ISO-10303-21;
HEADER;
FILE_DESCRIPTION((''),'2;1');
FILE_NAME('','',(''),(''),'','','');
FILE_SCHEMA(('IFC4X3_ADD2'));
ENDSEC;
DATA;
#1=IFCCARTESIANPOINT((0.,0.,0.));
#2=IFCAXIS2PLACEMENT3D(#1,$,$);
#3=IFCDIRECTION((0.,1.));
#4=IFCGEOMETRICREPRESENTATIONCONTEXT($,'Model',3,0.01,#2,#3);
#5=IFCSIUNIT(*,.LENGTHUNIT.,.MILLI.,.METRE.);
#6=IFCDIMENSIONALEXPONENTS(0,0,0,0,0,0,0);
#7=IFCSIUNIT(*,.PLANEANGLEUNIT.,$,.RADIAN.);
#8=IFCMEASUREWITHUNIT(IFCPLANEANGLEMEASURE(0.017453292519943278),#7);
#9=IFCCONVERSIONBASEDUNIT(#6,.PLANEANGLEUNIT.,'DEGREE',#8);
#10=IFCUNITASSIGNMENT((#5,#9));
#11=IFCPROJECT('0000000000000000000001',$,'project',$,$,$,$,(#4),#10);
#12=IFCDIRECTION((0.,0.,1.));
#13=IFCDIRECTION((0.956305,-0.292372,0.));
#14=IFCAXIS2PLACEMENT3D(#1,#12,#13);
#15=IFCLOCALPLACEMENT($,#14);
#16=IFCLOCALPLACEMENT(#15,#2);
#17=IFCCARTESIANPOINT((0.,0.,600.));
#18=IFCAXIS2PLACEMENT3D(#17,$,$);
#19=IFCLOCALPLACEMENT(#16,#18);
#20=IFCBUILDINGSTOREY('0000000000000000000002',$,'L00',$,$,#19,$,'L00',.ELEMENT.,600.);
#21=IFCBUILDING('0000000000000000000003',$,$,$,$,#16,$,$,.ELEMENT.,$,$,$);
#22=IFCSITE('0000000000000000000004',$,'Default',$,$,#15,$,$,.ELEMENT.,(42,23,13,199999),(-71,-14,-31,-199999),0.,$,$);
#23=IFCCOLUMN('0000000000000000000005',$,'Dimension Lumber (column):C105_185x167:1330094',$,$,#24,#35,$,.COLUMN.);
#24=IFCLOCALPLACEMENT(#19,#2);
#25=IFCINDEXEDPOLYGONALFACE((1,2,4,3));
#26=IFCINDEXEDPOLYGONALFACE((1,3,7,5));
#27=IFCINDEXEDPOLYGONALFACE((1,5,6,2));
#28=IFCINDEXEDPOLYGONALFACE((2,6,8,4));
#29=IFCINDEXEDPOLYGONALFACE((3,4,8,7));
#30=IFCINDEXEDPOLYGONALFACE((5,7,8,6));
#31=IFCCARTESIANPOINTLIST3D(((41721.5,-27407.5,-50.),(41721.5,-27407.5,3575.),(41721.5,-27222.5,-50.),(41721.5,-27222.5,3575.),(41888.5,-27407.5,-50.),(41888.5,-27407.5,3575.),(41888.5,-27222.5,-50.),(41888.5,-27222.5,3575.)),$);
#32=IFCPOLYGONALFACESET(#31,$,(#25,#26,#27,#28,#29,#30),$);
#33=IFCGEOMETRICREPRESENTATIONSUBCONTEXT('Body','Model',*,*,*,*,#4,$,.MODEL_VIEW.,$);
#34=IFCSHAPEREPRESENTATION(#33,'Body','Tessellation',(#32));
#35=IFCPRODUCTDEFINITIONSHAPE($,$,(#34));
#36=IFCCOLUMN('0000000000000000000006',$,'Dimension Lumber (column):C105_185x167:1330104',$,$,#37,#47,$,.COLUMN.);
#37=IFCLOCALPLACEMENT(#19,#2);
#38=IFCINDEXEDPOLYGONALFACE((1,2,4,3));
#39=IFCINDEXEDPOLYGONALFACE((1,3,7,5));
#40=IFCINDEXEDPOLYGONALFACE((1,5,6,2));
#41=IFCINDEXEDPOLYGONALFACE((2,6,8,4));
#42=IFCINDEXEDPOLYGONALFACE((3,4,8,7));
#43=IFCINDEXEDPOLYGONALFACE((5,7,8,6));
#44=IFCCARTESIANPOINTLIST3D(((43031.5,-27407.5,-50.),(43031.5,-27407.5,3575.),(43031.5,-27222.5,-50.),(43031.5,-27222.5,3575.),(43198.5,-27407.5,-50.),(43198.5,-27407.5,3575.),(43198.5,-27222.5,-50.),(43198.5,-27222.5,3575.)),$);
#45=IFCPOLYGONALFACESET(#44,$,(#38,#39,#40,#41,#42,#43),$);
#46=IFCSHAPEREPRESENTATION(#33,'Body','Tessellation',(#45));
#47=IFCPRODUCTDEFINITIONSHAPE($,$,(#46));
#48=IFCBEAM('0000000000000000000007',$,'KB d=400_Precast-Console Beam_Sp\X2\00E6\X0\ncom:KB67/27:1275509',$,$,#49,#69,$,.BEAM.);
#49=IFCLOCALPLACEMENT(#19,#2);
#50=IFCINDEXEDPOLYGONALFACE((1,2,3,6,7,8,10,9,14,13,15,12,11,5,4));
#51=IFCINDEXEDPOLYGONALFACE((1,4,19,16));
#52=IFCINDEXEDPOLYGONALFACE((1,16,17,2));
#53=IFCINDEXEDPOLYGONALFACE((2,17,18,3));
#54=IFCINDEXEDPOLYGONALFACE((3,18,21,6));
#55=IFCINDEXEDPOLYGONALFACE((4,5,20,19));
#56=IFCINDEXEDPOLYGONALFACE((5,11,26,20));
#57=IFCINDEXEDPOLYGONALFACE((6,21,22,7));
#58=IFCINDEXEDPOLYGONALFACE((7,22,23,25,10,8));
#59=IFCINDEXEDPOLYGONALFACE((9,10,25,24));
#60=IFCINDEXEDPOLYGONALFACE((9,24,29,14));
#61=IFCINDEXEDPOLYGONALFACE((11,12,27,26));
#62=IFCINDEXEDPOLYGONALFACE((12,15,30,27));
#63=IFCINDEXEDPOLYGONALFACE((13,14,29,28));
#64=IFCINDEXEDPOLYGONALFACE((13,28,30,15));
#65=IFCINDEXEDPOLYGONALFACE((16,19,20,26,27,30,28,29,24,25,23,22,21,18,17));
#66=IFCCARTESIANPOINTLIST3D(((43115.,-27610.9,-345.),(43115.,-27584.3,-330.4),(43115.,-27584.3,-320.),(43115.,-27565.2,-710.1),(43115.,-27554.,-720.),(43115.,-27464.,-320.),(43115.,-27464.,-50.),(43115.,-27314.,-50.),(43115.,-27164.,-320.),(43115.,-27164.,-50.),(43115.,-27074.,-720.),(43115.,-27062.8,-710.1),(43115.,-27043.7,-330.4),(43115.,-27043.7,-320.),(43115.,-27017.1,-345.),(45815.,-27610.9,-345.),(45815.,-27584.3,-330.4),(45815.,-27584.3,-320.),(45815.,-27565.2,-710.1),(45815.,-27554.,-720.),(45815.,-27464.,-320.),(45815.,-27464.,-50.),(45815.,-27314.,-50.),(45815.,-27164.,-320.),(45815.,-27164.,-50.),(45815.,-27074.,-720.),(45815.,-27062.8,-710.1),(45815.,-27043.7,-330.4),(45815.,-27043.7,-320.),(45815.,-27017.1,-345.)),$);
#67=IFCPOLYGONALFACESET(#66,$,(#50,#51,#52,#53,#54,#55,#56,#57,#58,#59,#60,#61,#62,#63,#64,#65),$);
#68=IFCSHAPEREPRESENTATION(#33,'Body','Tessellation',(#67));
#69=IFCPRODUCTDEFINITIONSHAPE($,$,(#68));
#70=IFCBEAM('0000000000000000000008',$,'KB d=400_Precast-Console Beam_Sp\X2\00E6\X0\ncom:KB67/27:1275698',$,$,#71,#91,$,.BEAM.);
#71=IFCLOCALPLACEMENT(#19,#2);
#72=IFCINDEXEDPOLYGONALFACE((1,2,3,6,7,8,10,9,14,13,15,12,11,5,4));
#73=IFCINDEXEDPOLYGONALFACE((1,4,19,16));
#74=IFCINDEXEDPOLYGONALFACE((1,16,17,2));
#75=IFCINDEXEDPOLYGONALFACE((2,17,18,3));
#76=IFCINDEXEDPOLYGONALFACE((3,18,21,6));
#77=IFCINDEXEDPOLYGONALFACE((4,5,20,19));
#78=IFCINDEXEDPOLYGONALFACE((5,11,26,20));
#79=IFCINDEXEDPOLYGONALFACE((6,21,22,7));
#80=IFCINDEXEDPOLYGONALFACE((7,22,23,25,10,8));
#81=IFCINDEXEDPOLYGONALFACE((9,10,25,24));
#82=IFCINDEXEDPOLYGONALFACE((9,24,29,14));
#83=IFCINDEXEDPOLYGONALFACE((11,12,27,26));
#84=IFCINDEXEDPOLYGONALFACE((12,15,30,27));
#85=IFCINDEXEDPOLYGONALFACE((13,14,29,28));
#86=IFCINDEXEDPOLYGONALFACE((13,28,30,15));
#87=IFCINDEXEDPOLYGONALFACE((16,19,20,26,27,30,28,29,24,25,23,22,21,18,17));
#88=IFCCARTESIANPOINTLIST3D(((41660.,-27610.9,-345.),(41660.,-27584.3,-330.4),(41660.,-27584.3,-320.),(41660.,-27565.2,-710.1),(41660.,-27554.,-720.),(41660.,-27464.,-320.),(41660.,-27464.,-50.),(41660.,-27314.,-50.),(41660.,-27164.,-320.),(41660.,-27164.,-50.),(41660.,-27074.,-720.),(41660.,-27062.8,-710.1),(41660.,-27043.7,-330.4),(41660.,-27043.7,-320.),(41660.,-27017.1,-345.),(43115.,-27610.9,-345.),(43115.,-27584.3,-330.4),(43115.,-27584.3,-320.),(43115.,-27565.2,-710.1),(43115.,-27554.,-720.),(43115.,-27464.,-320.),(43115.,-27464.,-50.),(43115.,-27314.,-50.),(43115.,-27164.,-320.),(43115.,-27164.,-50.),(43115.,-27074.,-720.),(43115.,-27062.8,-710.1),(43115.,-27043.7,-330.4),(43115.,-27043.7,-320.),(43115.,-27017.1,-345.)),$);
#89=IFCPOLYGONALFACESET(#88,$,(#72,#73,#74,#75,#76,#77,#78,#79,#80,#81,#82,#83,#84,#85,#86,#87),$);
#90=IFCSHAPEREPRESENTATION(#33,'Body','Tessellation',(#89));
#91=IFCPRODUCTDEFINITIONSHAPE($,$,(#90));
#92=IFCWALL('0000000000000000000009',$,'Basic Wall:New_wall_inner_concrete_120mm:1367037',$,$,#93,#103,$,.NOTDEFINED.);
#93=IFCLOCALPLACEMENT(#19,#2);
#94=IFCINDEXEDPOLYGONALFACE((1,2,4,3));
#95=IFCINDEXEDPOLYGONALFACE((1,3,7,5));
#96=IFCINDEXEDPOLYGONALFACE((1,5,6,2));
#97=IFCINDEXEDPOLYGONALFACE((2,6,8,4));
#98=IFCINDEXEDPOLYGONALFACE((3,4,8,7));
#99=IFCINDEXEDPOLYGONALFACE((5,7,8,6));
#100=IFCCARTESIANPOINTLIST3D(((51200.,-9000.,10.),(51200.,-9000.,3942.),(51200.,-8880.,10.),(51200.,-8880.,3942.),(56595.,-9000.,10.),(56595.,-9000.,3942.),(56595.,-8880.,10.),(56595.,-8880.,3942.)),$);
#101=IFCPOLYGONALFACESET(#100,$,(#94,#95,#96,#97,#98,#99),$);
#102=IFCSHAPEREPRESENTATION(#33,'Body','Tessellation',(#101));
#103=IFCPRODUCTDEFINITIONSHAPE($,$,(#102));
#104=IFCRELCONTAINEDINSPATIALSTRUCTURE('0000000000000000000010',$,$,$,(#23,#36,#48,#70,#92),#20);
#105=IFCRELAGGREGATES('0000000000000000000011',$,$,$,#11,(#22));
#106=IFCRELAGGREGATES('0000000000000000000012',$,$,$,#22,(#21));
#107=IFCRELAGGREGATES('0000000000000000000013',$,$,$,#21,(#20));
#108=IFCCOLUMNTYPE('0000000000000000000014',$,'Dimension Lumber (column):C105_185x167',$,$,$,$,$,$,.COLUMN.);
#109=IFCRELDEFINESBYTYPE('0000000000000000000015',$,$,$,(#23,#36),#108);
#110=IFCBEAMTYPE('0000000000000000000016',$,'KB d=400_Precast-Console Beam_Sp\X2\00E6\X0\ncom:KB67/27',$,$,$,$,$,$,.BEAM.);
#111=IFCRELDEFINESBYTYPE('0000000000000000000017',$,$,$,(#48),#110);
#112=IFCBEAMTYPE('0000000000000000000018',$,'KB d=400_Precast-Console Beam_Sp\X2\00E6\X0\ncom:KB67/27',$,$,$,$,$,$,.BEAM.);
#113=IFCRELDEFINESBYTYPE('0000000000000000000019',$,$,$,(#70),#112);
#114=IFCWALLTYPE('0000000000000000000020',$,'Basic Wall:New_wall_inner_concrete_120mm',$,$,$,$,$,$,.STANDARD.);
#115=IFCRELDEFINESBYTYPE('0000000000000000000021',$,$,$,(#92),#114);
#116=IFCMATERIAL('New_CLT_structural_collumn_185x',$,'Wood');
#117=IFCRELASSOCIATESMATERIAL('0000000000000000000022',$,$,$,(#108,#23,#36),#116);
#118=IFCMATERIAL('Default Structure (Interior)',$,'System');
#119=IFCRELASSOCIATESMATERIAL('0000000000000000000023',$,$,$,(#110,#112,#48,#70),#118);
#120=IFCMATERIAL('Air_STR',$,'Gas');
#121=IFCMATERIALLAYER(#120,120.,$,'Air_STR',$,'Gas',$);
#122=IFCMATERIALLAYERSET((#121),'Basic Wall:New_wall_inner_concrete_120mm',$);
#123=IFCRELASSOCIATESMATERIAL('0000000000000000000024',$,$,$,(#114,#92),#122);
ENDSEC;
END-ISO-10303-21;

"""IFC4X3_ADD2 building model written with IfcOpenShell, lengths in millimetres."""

from ifc_helpers import new_model, entity, si_unit, converted_unit, direction, frame, frame_2d, origin, origin_2d_with_axis, place, context, subcontext, project, spatial, polyline, rectangle, outline, extrude, source, transform, mapped, material, layer, layer_set, material_profile, profile_set, profile_usage, type_object, type_shapes, element, save


model = new_model("IFC4X3_ADD2")

# Units and contexts
model_context = context("Model", 3, precision=0.01, world=origin(), true_north=direction((0.0, 1.0)))
body_context = subcontext(model_context, "Body", "Model", "MODEL_VIEW")
ifc_project = project(units=[si_unit("LENGTHUNIT", "METRE", prefix="MILLI"), converted_unit("PLANEANGLEUNIT", "DEGREE", entity("IfcPlaneAngleMeasure", 0.017453292519943278), si_unit("PLANEANGLEUNIT", "RADIAN"), dimensions=[0, 0, 0, 0, 0, 0, 0])], contexts=[model_context])

# Site, building, storey
site_placement = place(None, frame((0.0, 0.0, 0.0), z_axis=(0.0, 0.0, 1.0), x_axis=(0.956305, -0.292372, 0.0)))
site = spatial("IfcSite", under=ifc_project, at=site_placement, Name="Default", CompositionType="ELEMENT", RefLatitude=(42, 23, 13, 199999), RefLongitude=(-71, -14, -31, -199999), RefElevation=0.0)
building_placement = place(site_placement, origin())
building = spatial("IfcBuilding", under=site, at=building_placement, CompositionType="ELEMENT")
storey_placement = place(building_placement, frame((0.0, 0.0, 600.0)))
storey = spatial("IfcBuildingStorey", under=building, at=storey_placement, Name="L00", LongName="L00", CompositionType="ELEMENT", Elevation=600.0)

# Columns
ifc_material_1 = material(Name="New_CLT_structural_collumn_185x", Category="Wood")
ifc_material_profile_1 = material_profile(ifc_material_1, rectangle(XDim=185.0, YDim=167.0, at=origin_2d_with_axis()), Name="C105_185x167")
ifc_profile_set_1 = profile_set([ifc_material_profile_1], Name="C105_185x167")
ifc_profile_usage_1 = profile_usage(ifc_profile_set_1)
column_type = type_object("IfcColumnType", Name="Dimension Lumber (column):C105_185x167", PredefinedType="COLUMN", material=ifc_profile_set_1)
shared_shape_1 = source(origin(), body_context, "Body", "SweptSolid", [
    extrude(rectangle(XDim=185.0, YDim=167.0, at=origin_2d_with_axis()), frame((0.0, 0.0, 550.0), z_axis=(0.0, 0.0, 1.0), x_axis=(-1.0, 0.0, 0.0)), (0.0, 0.0, 1.0), 3625.0),
])
type_shapes(column_type, [shared_shape_1])
for number, where, z_axis, x_axis, name in (
    (1, (41805.0, -27315.0, -600.0), (0.0, 0.0, 1.0), (0.0, 1.0, 0.0), "Dimension Lumber (column):C105_185x167:1330094"),
    (2, (43115.0, -27315.0, -600.0), (0.0, 0.0, 1.0), (0.0, 1.0, 0.0), "Dimension Lumber (column):C105_185x167:1330104"),
):
    element("IfcColumn", number, at=place(storey_placement, frame(where, z_axis=z_axis, x_axis=x_axis)), inside=storey, type_object=column_type, material=ifc_profile_usage_1, Name=name, PredefinedType="COLUMN", context=body_context, shape_type="MappedRepresentation", body=[
        mapped(shared_shape_1, transform((0.0, 0.0, 0.0), scale=1.0)),
    ])

# Beams
ifc_material_2 = material(Name="Default Structure (Interior)", Category="System")
ifc_material_profile_2 = material_profile(ifc_material_2, outline(polyline([(-240.0, -343.9), (240.0, -343.9), (251.2, -334.0), (296.9, 31.1), (270.3, 45.7), (270.3, 56.1), (150.0, 56.1), (150.0, 326.1), (0.0, 326.1), (-150.0, 326.1), (-150.0, 56.1), (-270.3, 56.1), (-270.3, 45.7), (-296.9, 31.1), (-251.2, -334.0), (-240.0, -343.9)])), Name="KB67/27")
ifc_profile_set_2 = profile_set([ifc_material_profile_2], Name="KB67/27")
ifc_profile_usage_2 = profile_usage(ifc_profile_set_2, cardinal=8)
beam_type_1 = type_object("IfcBeamType", Name="KB d=400_Precast-Console Beam_Spæncom:KB67/27", PredefinedType="BEAM", material=ifc_profile_set_2)
shared_shape_2 = source(origin(), body_context, "Body", "SweptSolid", [
    extrude(outline(polyline([(-240.0, -343.9), (240.0, -343.9), (251.2, -334.0), (296.9, 31.1), (270.3, 45.7), (270.3, 56.1), (150.0, 56.1), (150.0, 326.1), (0.0, 326.1), (-150.0, 326.1), (-150.0, 56.1), (-270.3, 56.1), (-270.3, 45.7), (-296.9, 31.1), (-251.2, -334.0), (-240.0, -343.9)])), frame((-1350.0, 0.0, 343.9), z_axis=(1.0, 0.0, 0.0), x_axis=(0.0, 1.0, 0.0)), (0.0, 0.0, 1.0), 2700.0),
])
type_shapes(beam_type_1, [shared_shape_2])
beam_1_placement = place(storey_placement, frame((44465.0, -27314.0, -720.0)))
element("IfcBeam", 3, at=beam_1_placement, inside=storey, type_object=beam_type_1, material=ifc_profile_usage_2, Name="KB d=400_Precast-Console Beam_Spæncom:KB67/27:1275509", PredefinedType="BEAM", context=body_context, shape_type="MappedRepresentation", body=[
    mapped(shared_shape_2, transform((0.0, 0.0, 0.0), scale=1.0)),
])
beam_type_2 = type_object("IfcBeamType", Name="KB d=400_Precast-Console Beam_Spæncom:KB67/27", PredefinedType="BEAM", material=ifc_profile_set_2)
shared_shape_3 = source(origin(), body_context, "Body", "SweptSolid", [
    extrude(outline(polyline([(-240.0, -343.9), (240.0, -343.9), (251.2, -334.0), (296.9, 31.1), (270.3, 45.7), (270.3, 56.1), (150.0, 56.1), (150.0, 326.1), (0.0, 326.1), (-150.0, 326.1), (-150.0, 56.1), (-270.3, 56.1), (-270.3, 45.7), (-296.9, 31.1), (-251.2, -334.0), (-240.0, -343.9)])), frame((-727.5, 0.0, 343.9), z_axis=(1.0, 0.0, 0.0), x_axis=(0.0, 1.0, 0.0)), (0.0, 0.0, 1.0), 1455.0),
])
type_shapes(beam_type_2, [shared_shape_3])
beam_2_placement = place(storey_placement, frame((42387.5, -27314.0, -720.0)))
element("IfcBeam", 4, at=beam_2_placement, inside=storey, type_object=beam_type_2, material=ifc_profile_usage_2, Name="KB d=400_Precast-Console Beam_Spæncom:KB67/27:1275698", PredefinedType="BEAM", context=body_context, shape_type="MappedRepresentation", body=[
    mapped(shared_shape_3, transform((0.0, 0.0, 0.0), scale=1.0)),
])

# Wall
ifc_material_3 = material(Name="Air_STR", Category="Gas")
ifc_layer = layer(ifc_material_3, 120.0, Name="Air_STR", Category="Gas")
ifc_layer_set = layer_set([ifc_layer], Name="Basic Wall:New_wall_inner_concrete_120mm")
wall_type = type_object("IfcWallType", Name="Basic Wall:New_wall_inner_concrete_120mm", PredefinedType="STANDARD", material=ifc_layer_set)
wall_placement = place(storey_placement, frame((51200.0, -8940.0, 10.0)))
element("IfcWall", 5, at=wall_placement, inside=storey, type_object=wall_type, material=ifc_layer_set, Name="Basic Wall:New_wall_inner_concrete_120mm:1367037", PredefinedType="NOTDEFINED", context=body_context, shape_type="SweptSolid", body=[
    extrude(rectangle(XDim=5395.0, YDim=120.0, at=frame_2d((2697.5, 0.0), x_axis=(-1.0, 0.0))), origin(), (0.0, 0.0, 1.0), 3932.0),
])

save(model, "model.ifc")
